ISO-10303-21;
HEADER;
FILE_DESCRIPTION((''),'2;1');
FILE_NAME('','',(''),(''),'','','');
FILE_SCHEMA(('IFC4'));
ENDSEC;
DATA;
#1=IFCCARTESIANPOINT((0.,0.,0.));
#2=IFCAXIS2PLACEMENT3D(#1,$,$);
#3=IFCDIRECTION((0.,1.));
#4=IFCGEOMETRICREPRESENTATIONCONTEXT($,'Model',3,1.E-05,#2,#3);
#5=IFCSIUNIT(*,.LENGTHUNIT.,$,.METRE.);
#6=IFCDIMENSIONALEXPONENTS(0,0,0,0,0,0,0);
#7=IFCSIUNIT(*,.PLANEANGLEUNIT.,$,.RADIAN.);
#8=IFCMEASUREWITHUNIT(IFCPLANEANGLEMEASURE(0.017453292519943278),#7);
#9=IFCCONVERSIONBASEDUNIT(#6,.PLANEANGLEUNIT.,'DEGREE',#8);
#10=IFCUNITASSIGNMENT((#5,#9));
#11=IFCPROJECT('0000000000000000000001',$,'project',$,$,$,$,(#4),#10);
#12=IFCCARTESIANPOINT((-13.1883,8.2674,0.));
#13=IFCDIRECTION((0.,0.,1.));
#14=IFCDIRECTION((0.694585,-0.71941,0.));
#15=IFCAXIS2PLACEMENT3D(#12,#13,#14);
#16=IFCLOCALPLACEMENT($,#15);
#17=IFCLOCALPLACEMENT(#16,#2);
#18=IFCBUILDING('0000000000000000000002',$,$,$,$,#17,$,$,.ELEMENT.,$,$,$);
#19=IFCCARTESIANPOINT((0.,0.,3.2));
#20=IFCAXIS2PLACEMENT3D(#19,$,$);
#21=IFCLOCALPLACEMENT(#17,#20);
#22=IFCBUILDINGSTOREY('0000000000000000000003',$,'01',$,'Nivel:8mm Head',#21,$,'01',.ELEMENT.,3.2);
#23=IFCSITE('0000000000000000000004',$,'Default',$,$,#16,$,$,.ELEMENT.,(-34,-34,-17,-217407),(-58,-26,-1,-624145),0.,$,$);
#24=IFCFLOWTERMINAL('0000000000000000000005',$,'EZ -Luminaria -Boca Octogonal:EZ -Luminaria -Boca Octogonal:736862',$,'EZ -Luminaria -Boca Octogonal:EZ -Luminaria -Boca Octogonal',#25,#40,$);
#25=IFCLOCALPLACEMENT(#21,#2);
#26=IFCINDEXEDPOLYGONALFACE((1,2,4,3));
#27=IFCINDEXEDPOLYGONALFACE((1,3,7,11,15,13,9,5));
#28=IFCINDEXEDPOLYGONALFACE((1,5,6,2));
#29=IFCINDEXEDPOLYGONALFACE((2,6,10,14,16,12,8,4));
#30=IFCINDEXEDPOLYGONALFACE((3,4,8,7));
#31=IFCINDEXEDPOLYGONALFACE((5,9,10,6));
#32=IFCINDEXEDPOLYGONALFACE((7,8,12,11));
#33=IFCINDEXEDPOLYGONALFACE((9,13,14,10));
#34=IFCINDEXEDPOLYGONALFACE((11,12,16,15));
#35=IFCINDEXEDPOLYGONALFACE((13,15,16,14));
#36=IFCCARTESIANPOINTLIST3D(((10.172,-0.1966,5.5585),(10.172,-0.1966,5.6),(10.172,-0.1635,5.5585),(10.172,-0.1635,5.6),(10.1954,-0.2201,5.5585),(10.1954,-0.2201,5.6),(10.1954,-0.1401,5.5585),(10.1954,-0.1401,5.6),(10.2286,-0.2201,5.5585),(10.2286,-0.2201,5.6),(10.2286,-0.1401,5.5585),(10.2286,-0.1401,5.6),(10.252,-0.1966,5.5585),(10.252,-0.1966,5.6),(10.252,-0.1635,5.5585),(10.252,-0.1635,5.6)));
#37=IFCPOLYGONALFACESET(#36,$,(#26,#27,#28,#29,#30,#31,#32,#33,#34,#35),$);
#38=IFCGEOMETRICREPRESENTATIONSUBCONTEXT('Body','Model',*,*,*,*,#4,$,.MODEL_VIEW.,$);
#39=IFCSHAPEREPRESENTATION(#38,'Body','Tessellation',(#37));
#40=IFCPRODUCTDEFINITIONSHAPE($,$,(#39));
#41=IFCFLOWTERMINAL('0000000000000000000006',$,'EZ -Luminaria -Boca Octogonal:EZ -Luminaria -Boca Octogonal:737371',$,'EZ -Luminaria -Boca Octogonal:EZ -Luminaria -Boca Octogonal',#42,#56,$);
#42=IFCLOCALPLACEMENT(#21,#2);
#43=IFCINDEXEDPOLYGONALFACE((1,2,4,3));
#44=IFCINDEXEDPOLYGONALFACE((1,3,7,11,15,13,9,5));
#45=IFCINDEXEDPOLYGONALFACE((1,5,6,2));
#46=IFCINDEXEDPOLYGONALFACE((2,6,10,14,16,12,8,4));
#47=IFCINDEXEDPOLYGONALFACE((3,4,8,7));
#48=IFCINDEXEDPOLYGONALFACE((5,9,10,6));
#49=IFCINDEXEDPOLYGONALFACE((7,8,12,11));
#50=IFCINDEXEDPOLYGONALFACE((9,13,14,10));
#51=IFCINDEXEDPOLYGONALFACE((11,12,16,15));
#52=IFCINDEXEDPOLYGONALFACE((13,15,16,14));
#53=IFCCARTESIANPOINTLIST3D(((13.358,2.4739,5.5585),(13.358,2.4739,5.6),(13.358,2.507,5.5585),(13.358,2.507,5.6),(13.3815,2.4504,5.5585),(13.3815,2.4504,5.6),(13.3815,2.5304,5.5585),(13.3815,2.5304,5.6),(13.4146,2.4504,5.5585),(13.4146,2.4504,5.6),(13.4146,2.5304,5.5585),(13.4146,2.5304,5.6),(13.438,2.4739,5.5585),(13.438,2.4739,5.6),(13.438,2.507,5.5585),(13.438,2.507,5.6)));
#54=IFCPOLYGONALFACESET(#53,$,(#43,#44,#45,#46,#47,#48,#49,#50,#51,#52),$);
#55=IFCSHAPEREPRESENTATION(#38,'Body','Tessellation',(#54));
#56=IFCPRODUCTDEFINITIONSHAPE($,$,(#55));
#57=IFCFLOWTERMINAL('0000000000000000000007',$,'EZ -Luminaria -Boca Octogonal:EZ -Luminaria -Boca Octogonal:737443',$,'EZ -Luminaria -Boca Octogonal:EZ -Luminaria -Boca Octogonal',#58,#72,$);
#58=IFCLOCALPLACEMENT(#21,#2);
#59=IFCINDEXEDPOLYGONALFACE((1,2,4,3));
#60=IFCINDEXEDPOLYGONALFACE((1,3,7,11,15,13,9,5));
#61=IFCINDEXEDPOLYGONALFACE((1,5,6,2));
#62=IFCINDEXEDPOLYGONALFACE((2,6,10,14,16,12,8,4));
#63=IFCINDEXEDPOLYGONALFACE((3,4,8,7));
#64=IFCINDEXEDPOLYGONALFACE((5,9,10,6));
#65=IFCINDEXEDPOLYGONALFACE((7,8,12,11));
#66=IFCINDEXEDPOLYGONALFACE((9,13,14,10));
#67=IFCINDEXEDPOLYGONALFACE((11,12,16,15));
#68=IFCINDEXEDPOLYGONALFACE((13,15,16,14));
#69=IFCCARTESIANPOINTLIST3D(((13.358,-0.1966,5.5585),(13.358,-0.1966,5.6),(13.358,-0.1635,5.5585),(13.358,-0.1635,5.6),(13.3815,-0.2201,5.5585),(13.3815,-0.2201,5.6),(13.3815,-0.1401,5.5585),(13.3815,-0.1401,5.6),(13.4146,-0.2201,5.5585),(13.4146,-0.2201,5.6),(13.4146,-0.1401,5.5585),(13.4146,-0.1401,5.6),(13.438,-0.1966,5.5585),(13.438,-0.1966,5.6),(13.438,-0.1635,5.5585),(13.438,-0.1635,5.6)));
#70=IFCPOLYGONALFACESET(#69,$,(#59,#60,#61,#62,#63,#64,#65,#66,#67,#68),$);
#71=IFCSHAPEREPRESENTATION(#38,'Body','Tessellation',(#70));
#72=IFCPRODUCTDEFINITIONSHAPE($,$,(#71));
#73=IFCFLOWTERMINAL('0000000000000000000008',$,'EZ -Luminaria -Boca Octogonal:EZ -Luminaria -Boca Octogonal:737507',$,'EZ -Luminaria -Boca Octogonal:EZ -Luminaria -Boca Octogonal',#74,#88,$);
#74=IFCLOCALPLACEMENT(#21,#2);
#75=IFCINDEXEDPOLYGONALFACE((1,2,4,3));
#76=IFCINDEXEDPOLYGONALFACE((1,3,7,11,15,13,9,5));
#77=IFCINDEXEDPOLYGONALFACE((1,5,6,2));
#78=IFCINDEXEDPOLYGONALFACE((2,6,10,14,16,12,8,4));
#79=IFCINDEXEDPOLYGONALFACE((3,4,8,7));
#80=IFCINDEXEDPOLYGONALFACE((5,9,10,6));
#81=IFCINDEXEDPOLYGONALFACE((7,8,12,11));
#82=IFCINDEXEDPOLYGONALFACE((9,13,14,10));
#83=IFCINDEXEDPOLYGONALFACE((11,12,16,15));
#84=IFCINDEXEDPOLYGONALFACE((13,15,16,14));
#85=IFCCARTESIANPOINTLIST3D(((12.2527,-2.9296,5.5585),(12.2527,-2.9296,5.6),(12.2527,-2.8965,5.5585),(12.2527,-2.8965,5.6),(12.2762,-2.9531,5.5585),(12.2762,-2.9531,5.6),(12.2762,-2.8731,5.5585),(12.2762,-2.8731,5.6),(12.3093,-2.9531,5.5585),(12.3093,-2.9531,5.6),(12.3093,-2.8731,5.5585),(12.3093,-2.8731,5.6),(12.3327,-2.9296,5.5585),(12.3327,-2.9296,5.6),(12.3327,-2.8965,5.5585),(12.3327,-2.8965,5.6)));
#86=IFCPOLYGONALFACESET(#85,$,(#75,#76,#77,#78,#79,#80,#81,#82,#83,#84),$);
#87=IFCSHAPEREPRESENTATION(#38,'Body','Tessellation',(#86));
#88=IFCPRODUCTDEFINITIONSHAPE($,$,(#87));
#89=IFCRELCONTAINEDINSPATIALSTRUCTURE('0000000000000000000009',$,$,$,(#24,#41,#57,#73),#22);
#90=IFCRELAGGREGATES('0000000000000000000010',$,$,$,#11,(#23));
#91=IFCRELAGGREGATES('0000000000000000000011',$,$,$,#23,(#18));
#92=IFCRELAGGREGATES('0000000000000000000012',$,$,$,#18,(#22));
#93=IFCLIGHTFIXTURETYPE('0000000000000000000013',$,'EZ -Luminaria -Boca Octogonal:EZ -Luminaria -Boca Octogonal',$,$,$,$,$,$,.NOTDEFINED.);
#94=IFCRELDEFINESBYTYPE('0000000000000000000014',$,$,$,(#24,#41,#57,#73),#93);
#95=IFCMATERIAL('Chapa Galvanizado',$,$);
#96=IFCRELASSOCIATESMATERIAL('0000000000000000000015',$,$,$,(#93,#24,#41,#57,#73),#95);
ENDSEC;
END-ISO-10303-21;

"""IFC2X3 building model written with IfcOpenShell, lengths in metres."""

from ifc_helpers import new_model, entity, si_unit, converted_unit, direction, frame, origin, place, context, subcontext, project, spatial, polyline, outline, extrude, source, transform, mapped, material, type_object, type_shapes, element, save


model = new_model("IFC2X3")

# Units and contexts
model_context = context("Model", 3, precision=1e-05, world=origin(), true_north=direction((0.0, 1.0)))
body_context = subcontext(model_context, "Body", "Model", "MODEL_VIEW")
ifc_project = project(units=[si_unit("LENGTHUNIT", "METRE"), converted_unit("PLANEANGLEUNIT", "DEGREE", entity("IfcPlaneAngleMeasure", 0.017453292519943278), si_unit("PLANEANGLEUNIT", "RADIAN"), dimensions=[0, 0, 0, 0, 0, 0, 0])], contexts=[model_context])

# Site, building, storey
site_placement = place(None, frame((-13.1883, 8.2674, 0.0), z_axis=(0.0, 0.0, 1.0), x_axis=(0.694585, -0.71941, 0.0)))
site = spatial("IfcSite", under=ifc_project, at=site_placement, Name="Default", CompositionType="ELEMENT", RefLatitude=(-34, -34, -17, -217407), RefLongitude=(-58, -26, -1, -624145), RefElevation=0.0)
building_placement = place(site_placement, origin())
building = spatial("IfcBuilding", under=site, at=building_placement, CompositionType="ELEMENT")
storey_placement = place(building_placement, frame((0.0, 0.0, 3.2)))
storey = spatial("IfcBuildingStorey", under=building, at=storey_placement, Name="01", ObjectType="Nivel:8mm Head", LongName="01", CompositionType="ELEMENT", Elevation=3.2)

# Flow terminals
ifc_material_1 = material(Name="Chapa Galvanizado")
light_fixture_type = type_object("IfcLightFixtureType", Name="EZ -Luminaria -Boca Octogonal:EZ -Luminaria -Boca Octogonal", PredefinedType="NOTDEFINED", material=ifc_material_1)
shared_shape_1 = source(origin(), body_context, "Body", "SweptSolid", [
    extrude(outline(polyline([(-0.0166, -0.04), (0.0166, -0.04), (0.04, -0.0166), (0.04, 0.0166), (0.0166, 0.04), (-0.0166, 0.04), (-0.04, 0.0166), (-0.04, -0.0166), (-0.0166, -0.04)])), frame((0.0, 0.0, -0.0415), z_axis=(0.0, 0.0, 1.0), x_axis=(0.0, -1.0, 0.0)), (0.0, 0.0, 1.0), 0.0415),
])
type_shapes(light_fixture_type, [shared_shape_1])
for number, where, name in (
    (1, (10.212, -0.1801, 5.6), "EZ -Luminaria -Boca Octogonal:EZ -Luminaria -Boca Octogonal:736862"),
    (2, (13.398, 2.4904, 5.6), "EZ -Luminaria -Boca Octogonal:EZ -Luminaria -Boca Octogonal:737371"),
    (3, (13.398, -0.1801, 5.6), "EZ -Luminaria -Boca Octogonal:EZ -Luminaria -Boca Octogonal:737443"),
    (4, (12.2927, -2.9131, 5.6), "EZ -Luminaria -Boca Octogonal:EZ -Luminaria -Boca Octogonal:737507"),
):
    element("IfcFlowTerminal", number, at=place(storey_placement, frame(where)), inside=storey, type_object=light_fixture_type, material=ifc_material_1, Name=name, ObjectType="EZ -Luminaria -Boca Octogonal:EZ -Luminaria -Boca Octogonal", context=body_context, shape_type="MappedRepresentation", body=[
        mapped(shared_shape_1, transform((0.0, 0.0, 0.0), scale=1.0)),
    ])

save(model, "model.ifc")
